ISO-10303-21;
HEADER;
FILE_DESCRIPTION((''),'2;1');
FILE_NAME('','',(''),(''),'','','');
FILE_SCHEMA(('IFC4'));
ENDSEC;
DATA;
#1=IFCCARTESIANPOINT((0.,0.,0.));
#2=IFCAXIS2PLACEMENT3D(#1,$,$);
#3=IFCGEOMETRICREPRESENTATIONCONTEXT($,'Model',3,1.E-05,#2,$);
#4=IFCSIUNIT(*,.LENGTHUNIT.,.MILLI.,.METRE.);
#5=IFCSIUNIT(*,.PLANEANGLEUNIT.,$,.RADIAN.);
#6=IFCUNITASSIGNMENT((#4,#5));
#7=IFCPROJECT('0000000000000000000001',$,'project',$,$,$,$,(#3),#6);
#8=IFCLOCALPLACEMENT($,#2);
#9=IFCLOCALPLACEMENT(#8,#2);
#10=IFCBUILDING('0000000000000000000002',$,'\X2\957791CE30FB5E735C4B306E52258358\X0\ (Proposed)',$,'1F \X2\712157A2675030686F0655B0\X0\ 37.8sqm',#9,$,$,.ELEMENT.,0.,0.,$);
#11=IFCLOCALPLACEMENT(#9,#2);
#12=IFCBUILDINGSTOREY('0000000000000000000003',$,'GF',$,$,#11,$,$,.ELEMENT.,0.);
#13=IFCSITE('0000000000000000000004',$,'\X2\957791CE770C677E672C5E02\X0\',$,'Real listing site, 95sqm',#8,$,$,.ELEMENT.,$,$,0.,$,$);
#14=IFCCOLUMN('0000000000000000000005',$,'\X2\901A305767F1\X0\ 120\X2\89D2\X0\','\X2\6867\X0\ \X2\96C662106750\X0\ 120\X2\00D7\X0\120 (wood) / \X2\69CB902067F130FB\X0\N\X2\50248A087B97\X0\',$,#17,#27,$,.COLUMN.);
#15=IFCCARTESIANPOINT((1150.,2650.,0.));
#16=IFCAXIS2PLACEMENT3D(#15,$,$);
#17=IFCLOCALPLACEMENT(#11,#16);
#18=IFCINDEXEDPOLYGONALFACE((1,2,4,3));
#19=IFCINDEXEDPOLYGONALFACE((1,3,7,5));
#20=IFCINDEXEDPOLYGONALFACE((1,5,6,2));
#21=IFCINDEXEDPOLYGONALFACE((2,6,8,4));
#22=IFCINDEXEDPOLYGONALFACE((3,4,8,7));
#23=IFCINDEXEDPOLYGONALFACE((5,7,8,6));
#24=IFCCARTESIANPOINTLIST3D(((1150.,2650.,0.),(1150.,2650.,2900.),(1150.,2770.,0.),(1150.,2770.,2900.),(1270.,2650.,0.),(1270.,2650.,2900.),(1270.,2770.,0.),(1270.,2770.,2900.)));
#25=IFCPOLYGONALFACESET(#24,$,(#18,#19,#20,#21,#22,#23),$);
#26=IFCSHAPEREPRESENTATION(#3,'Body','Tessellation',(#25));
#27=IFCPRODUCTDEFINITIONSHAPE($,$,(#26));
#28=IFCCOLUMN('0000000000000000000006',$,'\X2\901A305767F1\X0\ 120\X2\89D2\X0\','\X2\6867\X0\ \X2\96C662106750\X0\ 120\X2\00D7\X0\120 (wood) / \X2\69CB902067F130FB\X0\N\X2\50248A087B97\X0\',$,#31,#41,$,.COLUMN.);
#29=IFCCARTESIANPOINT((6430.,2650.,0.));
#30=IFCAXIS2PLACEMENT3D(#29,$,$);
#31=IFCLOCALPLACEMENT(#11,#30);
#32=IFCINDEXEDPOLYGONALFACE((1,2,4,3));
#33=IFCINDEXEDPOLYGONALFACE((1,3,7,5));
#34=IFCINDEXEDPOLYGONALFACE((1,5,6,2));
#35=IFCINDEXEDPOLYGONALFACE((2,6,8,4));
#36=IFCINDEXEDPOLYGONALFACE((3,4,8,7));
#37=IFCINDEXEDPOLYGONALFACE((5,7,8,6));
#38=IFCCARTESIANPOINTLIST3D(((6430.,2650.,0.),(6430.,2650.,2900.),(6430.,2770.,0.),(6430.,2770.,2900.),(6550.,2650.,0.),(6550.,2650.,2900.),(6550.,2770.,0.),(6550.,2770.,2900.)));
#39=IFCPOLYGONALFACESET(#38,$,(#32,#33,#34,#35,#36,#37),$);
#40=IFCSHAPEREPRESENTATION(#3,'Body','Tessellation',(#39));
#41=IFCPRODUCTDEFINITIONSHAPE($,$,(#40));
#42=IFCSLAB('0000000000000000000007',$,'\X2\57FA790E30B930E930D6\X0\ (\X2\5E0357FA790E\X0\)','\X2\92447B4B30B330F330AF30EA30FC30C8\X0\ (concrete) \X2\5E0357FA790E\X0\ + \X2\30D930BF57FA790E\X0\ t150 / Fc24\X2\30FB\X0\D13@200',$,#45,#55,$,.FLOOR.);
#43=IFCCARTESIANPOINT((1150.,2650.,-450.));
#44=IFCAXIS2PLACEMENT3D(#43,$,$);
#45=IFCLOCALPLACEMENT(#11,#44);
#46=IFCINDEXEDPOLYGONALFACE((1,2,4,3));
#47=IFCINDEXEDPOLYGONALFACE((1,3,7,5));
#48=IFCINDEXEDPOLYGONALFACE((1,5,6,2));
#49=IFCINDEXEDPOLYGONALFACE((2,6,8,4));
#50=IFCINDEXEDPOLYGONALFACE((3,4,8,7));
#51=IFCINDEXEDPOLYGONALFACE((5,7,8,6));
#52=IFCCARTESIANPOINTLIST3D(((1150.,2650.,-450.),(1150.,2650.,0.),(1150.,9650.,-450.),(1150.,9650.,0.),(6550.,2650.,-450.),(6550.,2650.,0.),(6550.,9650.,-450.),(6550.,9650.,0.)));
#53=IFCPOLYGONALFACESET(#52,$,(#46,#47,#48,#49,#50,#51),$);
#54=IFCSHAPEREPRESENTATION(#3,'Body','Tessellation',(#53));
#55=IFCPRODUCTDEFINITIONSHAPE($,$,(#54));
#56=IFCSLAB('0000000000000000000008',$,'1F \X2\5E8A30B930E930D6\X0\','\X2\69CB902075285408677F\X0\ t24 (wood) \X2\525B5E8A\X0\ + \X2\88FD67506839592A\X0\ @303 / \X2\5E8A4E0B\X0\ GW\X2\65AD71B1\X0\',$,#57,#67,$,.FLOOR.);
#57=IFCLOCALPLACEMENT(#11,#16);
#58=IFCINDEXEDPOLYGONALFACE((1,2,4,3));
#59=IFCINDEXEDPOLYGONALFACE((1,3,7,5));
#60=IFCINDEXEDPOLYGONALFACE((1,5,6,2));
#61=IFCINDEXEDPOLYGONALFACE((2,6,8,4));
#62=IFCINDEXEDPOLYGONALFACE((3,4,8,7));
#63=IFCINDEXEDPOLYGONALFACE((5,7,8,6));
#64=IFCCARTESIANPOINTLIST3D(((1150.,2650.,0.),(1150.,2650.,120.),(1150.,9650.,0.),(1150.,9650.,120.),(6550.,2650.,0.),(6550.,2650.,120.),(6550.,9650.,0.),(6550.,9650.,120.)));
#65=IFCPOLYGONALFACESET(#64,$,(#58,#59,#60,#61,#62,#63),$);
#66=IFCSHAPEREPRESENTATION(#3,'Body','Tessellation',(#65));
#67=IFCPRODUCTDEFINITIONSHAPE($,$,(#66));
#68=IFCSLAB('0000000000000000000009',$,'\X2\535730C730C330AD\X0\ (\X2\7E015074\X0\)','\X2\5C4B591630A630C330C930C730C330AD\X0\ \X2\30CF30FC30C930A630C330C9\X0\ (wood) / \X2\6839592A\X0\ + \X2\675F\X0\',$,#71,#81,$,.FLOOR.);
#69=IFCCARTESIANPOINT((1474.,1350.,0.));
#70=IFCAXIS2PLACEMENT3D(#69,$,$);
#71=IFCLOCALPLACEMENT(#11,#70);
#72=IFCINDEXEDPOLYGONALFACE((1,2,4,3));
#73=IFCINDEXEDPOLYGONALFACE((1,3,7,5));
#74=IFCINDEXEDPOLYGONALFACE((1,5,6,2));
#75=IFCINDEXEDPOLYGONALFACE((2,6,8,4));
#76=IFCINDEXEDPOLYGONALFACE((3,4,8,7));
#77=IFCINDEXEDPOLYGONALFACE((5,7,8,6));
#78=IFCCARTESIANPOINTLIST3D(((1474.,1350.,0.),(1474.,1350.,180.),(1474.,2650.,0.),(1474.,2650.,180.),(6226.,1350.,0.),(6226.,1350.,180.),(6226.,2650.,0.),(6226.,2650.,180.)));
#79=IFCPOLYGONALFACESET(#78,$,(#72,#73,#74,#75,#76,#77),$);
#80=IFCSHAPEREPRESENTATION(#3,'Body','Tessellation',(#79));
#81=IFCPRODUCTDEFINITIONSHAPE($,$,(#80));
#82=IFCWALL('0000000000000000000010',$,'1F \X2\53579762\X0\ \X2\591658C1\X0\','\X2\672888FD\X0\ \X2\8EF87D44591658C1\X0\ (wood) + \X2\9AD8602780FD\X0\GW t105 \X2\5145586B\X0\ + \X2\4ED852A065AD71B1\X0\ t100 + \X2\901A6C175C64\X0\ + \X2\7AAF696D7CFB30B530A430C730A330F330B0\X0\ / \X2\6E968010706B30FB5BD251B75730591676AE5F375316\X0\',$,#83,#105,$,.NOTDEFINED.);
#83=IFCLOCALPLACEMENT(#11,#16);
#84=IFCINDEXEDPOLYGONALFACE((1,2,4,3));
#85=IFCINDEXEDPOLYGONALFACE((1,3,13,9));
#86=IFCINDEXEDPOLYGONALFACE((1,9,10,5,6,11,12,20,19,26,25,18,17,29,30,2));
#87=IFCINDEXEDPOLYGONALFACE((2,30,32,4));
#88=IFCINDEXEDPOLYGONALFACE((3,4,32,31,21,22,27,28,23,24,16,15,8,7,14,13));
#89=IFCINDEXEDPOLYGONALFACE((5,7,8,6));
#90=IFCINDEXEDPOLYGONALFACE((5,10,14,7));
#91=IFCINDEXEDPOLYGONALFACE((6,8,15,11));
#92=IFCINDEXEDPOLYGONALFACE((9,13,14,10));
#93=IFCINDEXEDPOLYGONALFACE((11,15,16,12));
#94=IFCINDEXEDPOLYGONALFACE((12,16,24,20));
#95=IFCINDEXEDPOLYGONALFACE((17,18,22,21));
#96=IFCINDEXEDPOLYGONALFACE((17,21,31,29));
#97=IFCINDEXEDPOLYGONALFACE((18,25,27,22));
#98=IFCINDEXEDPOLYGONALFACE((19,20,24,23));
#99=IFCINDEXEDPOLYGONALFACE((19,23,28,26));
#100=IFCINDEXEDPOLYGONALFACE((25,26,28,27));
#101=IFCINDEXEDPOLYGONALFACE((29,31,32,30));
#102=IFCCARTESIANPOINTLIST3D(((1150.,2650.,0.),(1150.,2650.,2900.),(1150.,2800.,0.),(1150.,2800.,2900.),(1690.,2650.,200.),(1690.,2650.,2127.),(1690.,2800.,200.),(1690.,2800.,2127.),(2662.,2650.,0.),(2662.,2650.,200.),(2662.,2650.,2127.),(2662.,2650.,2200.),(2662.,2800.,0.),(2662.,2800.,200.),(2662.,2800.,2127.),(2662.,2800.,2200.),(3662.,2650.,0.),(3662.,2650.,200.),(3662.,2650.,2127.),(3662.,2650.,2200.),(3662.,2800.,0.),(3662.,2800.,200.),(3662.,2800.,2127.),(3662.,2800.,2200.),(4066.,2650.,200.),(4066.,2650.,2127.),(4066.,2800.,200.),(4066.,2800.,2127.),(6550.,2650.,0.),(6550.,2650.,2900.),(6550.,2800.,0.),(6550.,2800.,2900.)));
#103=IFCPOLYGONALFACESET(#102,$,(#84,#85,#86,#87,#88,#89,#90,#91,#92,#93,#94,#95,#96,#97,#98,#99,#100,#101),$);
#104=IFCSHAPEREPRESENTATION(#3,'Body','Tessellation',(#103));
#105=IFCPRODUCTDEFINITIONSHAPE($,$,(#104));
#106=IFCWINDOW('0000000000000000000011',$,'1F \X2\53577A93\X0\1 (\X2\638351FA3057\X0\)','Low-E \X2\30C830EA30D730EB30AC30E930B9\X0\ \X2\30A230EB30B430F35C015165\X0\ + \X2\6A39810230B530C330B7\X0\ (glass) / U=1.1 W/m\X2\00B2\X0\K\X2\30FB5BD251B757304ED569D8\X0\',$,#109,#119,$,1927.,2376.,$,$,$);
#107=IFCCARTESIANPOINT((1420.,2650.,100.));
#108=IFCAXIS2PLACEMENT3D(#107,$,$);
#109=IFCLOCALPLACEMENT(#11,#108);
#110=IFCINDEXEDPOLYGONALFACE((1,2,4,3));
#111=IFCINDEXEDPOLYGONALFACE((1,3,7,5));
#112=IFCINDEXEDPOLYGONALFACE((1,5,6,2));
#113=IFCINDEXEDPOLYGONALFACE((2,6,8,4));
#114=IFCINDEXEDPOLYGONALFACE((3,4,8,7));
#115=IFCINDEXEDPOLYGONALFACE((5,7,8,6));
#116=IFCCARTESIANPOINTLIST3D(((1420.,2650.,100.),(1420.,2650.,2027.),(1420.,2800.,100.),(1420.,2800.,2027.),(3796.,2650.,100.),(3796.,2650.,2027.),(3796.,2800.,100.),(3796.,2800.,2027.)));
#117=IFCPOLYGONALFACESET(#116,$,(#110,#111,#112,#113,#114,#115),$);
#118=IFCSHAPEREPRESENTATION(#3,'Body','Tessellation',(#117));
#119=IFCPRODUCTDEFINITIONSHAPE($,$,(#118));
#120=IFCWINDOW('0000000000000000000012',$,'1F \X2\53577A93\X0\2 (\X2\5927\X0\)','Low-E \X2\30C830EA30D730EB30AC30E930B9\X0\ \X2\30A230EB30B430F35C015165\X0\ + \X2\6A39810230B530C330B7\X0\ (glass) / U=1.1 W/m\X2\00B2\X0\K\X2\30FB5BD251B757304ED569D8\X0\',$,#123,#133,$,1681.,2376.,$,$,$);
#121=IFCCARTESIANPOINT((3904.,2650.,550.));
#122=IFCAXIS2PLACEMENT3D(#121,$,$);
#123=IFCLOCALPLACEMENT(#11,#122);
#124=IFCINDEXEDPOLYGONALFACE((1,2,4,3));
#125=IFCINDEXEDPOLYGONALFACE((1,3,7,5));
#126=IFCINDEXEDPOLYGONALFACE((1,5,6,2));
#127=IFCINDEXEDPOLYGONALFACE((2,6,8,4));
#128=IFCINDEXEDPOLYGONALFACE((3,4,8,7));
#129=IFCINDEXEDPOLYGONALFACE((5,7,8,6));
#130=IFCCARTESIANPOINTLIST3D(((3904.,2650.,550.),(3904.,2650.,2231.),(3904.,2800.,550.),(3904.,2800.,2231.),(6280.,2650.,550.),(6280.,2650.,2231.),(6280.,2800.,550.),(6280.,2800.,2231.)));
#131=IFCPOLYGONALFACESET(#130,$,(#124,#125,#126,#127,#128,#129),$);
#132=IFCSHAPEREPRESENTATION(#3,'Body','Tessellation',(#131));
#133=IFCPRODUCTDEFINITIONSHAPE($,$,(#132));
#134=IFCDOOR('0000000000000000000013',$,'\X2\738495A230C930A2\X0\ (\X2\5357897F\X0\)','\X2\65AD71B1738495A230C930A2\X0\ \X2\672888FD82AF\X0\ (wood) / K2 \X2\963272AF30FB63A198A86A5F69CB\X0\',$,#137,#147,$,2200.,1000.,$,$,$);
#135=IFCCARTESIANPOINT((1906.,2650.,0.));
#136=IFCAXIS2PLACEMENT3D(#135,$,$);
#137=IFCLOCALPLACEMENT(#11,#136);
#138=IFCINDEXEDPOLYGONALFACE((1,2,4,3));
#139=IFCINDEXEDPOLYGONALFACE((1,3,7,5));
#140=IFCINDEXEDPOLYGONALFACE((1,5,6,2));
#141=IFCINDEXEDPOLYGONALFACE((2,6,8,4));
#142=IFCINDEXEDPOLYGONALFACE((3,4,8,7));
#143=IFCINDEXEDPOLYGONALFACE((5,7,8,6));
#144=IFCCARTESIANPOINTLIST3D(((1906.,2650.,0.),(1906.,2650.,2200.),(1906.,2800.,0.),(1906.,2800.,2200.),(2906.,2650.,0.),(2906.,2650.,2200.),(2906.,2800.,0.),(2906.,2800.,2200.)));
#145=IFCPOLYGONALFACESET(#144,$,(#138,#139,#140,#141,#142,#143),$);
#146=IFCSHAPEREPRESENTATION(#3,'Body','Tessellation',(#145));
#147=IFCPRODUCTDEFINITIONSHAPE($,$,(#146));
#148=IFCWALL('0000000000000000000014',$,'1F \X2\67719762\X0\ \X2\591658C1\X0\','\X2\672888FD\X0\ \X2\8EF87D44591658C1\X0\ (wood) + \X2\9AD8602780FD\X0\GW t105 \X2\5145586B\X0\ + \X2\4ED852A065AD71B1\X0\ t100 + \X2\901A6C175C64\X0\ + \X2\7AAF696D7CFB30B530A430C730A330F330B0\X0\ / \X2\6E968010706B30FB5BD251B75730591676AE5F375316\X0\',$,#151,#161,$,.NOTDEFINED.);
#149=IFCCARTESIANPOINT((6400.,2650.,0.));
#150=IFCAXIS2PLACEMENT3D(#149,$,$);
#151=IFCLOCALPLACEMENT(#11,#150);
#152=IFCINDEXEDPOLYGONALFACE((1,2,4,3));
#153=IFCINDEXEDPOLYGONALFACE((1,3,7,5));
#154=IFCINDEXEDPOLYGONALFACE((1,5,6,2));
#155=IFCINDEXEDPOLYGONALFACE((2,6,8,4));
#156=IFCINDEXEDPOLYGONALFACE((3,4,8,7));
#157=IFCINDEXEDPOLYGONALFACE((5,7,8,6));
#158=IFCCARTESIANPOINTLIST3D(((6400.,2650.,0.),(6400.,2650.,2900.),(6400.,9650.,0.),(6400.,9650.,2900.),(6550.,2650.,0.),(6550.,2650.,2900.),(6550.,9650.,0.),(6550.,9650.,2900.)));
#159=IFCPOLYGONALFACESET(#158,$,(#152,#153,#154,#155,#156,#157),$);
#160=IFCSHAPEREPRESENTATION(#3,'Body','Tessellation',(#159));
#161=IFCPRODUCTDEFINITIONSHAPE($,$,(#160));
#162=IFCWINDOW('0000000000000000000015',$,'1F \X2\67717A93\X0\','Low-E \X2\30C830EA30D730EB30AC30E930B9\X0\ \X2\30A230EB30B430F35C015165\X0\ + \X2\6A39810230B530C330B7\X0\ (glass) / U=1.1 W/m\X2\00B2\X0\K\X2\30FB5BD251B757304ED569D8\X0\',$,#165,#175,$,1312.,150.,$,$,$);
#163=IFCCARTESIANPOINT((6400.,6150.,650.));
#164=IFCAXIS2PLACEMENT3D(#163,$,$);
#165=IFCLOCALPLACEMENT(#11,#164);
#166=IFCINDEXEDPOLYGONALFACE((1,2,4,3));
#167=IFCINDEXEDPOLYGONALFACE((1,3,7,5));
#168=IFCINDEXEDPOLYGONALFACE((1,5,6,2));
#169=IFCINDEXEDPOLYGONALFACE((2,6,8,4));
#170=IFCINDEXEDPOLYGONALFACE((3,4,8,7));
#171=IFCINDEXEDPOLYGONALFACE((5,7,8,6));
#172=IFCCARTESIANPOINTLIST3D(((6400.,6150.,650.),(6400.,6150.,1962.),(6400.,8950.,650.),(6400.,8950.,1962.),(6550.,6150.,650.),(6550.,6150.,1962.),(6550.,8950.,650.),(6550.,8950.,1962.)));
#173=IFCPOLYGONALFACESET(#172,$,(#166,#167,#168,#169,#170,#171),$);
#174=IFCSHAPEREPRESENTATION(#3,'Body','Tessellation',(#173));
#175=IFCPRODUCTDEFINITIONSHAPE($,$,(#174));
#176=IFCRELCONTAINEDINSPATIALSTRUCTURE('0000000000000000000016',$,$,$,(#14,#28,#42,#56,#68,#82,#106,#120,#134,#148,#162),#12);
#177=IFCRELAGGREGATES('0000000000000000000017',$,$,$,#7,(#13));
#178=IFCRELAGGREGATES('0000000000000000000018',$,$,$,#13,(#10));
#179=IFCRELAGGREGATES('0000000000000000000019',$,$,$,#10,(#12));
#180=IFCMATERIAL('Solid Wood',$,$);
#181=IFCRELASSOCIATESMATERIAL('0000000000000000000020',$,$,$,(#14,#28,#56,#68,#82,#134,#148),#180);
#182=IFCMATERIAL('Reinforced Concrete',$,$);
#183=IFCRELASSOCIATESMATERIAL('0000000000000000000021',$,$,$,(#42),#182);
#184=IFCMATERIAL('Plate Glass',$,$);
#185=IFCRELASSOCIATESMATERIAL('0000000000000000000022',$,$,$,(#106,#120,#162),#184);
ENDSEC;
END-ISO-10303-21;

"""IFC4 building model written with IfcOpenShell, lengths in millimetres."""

from ifc_helpers import new_model, si_unit, frame, frame_2d, origin, place, context, project, spatial, rectangle, extrude, material, element, fill, save


model = new_model("IFC4")

# Units and contexts
model_context = context("Model", 3, precision=1e-05, world=origin())
ifc_project = project(units=[si_unit("LENGTHUNIT", "METRE", prefix="MILLI"), si_unit("PLANEANGLEUNIT", "RADIAN")], contexts=[model_context])

# Site, building, storey
site_placement = place(None, origin())
site = spatial("IfcSite", under=ifc_project, at=site_placement, Name="長野県松本市", ObjectType="Real listing site, 95sqm", CompositionType="ELEMENT", RefElevation=0.0)
building_placement = place(site_placement, origin())
building = spatial("IfcBuilding", under=site, at=building_placement, Name="長野・平屋の別荘 (Proposed)", ObjectType="1F 無垢材と漆喰 37.8sqm", CompositionType="ELEMENT", ElevationOfRefHeight=0.0, ElevationOfTerrain=0.0)
storey_placement = place(building_placement, origin())
storey = spatial("IfcBuildingStorey", under=building, at=storey_placement, Name="GF", CompositionType="ELEMENT", Elevation=0.0)

# Columns
ifc_material_1 = material(Name="Solid Wood")
column_1_placement = place(storey_placement, frame((1150.0, 2650.0, 0.0)))
element("IfcColumn", 1, at=column_1_placement, inside=storey, material=ifc_material_1, Name="通し柱 120角", Description="桧 集成材 120×120 (wood) / 構造柱・N値計算", PredefinedType="COLUMN", context=model_context, shape_type="SweptSolid", body=[
    extrude(rectangle(XDim=120.0, YDim=120.0, at=frame_2d((60.0, 60.0))), frame((1150.0, 2650.0, 0.0)), (0.0, 0.0, 1.0), 2900.0),
])
column_2_placement = place(storey_placement, frame((6430.0, 2650.0, 0.0)))
element("IfcColumn", 2, at=column_2_placement, inside=storey, material=ifc_material_1, Name="通し柱 120角", Description="桧 集成材 120×120 (wood) / 構造柱・N値計算", PredefinedType="COLUMN", context=model_context, shape_type="SweptSolid", body=[
    extrude(rectangle(XDim=120.0, YDim=120.0, at=frame_2d((60.0, 60.0))), frame((6430.0, 2650.0, 0.0)), (0.0, 0.0, 1.0), 2900.0),
])

# Slabs
ifc_material_2 = material(Name="Reinforced Concrete")
slab_1_placement = place(storey_placement, frame((1150.0, 2650.0, -450.0)))
element("IfcSlab", 3, at=slab_1_placement, inside=storey, material=ifc_material_2, Name="基礎スラブ (布基礎)", Description="鉄筋コンクリート (concrete) 布基礎 + ベタ基礎 t150 / Fc24・D13@200", PredefinedType="FLOOR", context=model_context, shape_type="SweptSolid", body=[
    extrude(rectangle(XDim=5400.0, YDim=7000.0, at=frame_2d((2700.0, 3500.0))), frame((1150.0, 2650.0, -450.0)), (0.0, 0.0, 1.0), 450.0),
])
slab_2_placement = place(storey_placement, frame((1150.0, 2650.0, 0.0)))
element("IfcSlab", 4, at=slab_2_placement, inside=storey, material=ifc_material_1, Name="1F 床スラブ", Description="構造用合板 t24 (wood) 剛床 + 製材根太 @303 / 床下 GW断熱", PredefinedType="FLOOR", context=model_context, shape_type="SweptSolid", body=[
    extrude(rectangle(XDim=5400.0, YDim=7000.0, at=frame_2d((2700.0, 3500.0))), frame((1150.0, 2650.0, 0.0)), (0.0, 0.0, 1.0), 120.0),
])
slab_3_placement = place(storey_placement, frame((1474.0, 1350.0, 0.0)))
element("IfcSlab", 5, at=slab_3_placement, inside=storey, material=ifc_material_1, Name="南デッキ (縁側)", Description="屋外ウッドデッキ ハードウッド (wood) / 根太 + 束", PredefinedType="FLOOR", context=model_context, shape_type="SweptSolid", body=[
    extrude(rectangle(XDim=4752.0, YDim=1300.0, at=frame_2d((2376.0, 650.0))), frame((1474.0, 1350.0, 0.0)), (0.0, 0.0, 1.0), 180.0),
])

# Wall, openings, windows, door
wall_1_placement = place(storey_placement, frame((1150.0, 2650.0, 0.0)))
wall_1 = element("IfcWall", 6, at=wall_1_placement, inside=storey, material=ifc_material_1, Name="1F 南面 外壁", Description="木製 軸組外壁 (wood) + 高性能GW t105 充填 + 付加断熱 t100 + 通気層 + 窯業系サイディング / 準耐火・寒冷地外皮強化", PredefinedType="NOTDEFINED", context=model_context, shape_type="SweptSolid", body=[
    extrude(rectangle(XDim=5400.0, YDim=150.0, at=frame_2d((2700.0, 75.0))), frame((1150.0, 2650.0, 0.0)), (0.0, 0.0, 1.0), 2900.0),
])
opening_1_placement = place(storey_placement, frame((1420.0, 2650.0, 100.0)))
opening_1 = element("IfcOpeningElement", 7, at=opening_1_placement, cuts=wall_1, PredefinedType="NOTDEFINED", context=model_context, shape_type="SweptSolid", body=[
    extrude(rectangle(XDim=2376.0, YDim=150.0, at=frame_2d((1188.0, 75.0))), frame((1420.0, 2650.0, 100.0)), (0.0, 0.0, 1.0), 1927.0),
])
opening_2_placement = place(storey_placement, frame((3904.0, 2650.0, 550.0)))
opening_2 = element("IfcOpeningElement", 8, at=opening_2_placement, cuts=wall_1, PredefinedType="NOTDEFINED", context=model_context, shape_type="SweptSolid", body=[
    extrude(rectangle(XDim=2376.0, YDim=150.0, at=frame_2d((1188.0, 75.0))), frame((3904.0, 2650.0, 550.0)), (0.0, 0.0, 1.0), 1681.0),
])
opening_3_placement = place(storey_placement, frame((1906.0, 2650.0, 0.0)))
opening_3 = element("IfcOpeningElement", 9, at=opening_3_placement, cuts=wall_1, PredefinedType="NOTDEFINED", context=model_context, shape_type="SweptSolid", body=[
    extrude(rectangle(XDim=1000.0, YDim=150.0, at=frame_2d((500.0, 75.0))), frame((1906.0, 2650.0, 0.0)), (0.0, 0.0, 1.0), 2200.0),
])
ifc_material_3 = material(Name="Plate Glass")
window_1_placement = place(storey_placement, frame((1420.0, 2650.0, 100.0)))
window_1 = element("IfcWindow", 10, at=window_1_placement, inside=storey, material=ifc_material_3, Name="1F 南窓1 (掃出し)", Description="Low-E トリプルガラス アルゴン封入 + 樹脂サッシ (glass) / U=1.1 W/m²K・寒冷地仕様", OverallHeight=1927.0, OverallWidth=2376.0, context=model_context, shape_type="SweptSolid", body=[
    extrude(rectangle(XDim=2376.0, YDim=150.0, at=frame_2d((1188.0, 75.0))), frame((1420.0, 2650.0, 100.0)), (0.0, 0.0, 1.0), 1927.0),
])
fill(opening_1, window_1)
window_2_placement = place(storey_placement, frame((3904.0, 2650.0, 550.0)))
window_2 = element("IfcWindow", 11, at=window_2_placement, inside=storey, material=ifc_material_3, Name="1F 南窓2 (大)", Description="Low-E トリプルガラス アルゴン封入 + 樹脂サッシ (glass) / U=1.1 W/m²K・寒冷地仕様", OverallHeight=1681.0, OverallWidth=2376.0, context=model_context, shape_type="SweptSolid", body=[
    extrude(rectangle(XDim=2376.0, YDim=150.0, at=frame_2d((1188.0, 75.0))), frame((3904.0, 2650.0, 550.0)), (0.0, 0.0, 1.0), 1681.0),
])
fill(opening_2, window_2)
door_placement = place(storey_placement, frame((1906.0, 2650.0, 0.0)))
door = element("IfcDoor", 12, at=door_placement, inside=storey, material=ifc_material_1, Name="玄関ドア (南西)", Description="断熱玄関ドア 木製芯 (wood) / K2 防犯・採風機構", OverallHeight=2200.0, OverallWidth=1000.0, context=model_context, shape_type="SweptSolid", body=[
    extrude(rectangle(XDim=1000.0, YDim=150.0, at=frame_2d((500.0, 75.0))), frame((1906.0, 2650.0, 0.0)), (0.0, 0.0, 1.0), 2200.0),
])
fill(opening_3, door)

# Wall, opening, window
wall_2_placement = place(storey_placement, frame((6400.0, 2650.0, 0.0)))
wall_2 = element("IfcWall", 13, at=wall_2_placement, inside=storey, material=ifc_material_1, Name="1F 東面 外壁", Description="木製 軸組外壁 (wood) + 高性能GW t105 充填 + 付加断熱 t100 + 通気層 + 窯業系サイディング / 準耐火・寒冷地外皮強化", PredefinedType="NOTDEFINED", context=model_context, shape_type="SweptSolid", body=[
    extrude(rectangle(XDim=150.0, YDim=7000.0, at=frame_2d((75.0, 3500.0))), frame((6400.0, 2650.0, 0.0)), (0.0, 0.0, 1.0), 2900.0),
])
opening_4_placement = place(storey_placement, frame((6400.0, 6150.0, 650.0)))
opening_4 = element("IfcOpeningElement", 14, at=opening_4_placement, cuts=wall_2, PredefinedType="NOTDEFINED", context=model_context, shape_type="SweptSolid", body=[
    extrude(rectangle(XDim=150.0, YDim=2800.0, at=frame_2d((75.0, 1400.0))), frame((6400.0, 6150.0, 650.0)), (0.0, 0.0, 1.0), 1312.0),
])
window_3_placement = place(storey_placement, frame((6400.0, 6150.0, 650.0)))
window_3 = element("IfcWindow", 15, at=window_3_placement, inside=storey, material=ifc_material_3, Name="1F 東窓", Description="Low-E トリプルガラス アルゴン封入 + 樹脂サッシ (glass) / U=1.1 W/m²K・寒冷地仕様", OverallHeight=1312.0, OverallWidth=150.0, context=model_context, shape_type="SweptSolid", body=[
    extrude(rectangle(XDim=150.0, YDim=2800.0, at=frame_2d((75.0, 1400.0))), frame((6400.0, 6150.0, 650.0)), (0.0, 0.0, 1.0), 1312.0),
])
fill(opening_4, window_3)

save(model, "model.ifc")
